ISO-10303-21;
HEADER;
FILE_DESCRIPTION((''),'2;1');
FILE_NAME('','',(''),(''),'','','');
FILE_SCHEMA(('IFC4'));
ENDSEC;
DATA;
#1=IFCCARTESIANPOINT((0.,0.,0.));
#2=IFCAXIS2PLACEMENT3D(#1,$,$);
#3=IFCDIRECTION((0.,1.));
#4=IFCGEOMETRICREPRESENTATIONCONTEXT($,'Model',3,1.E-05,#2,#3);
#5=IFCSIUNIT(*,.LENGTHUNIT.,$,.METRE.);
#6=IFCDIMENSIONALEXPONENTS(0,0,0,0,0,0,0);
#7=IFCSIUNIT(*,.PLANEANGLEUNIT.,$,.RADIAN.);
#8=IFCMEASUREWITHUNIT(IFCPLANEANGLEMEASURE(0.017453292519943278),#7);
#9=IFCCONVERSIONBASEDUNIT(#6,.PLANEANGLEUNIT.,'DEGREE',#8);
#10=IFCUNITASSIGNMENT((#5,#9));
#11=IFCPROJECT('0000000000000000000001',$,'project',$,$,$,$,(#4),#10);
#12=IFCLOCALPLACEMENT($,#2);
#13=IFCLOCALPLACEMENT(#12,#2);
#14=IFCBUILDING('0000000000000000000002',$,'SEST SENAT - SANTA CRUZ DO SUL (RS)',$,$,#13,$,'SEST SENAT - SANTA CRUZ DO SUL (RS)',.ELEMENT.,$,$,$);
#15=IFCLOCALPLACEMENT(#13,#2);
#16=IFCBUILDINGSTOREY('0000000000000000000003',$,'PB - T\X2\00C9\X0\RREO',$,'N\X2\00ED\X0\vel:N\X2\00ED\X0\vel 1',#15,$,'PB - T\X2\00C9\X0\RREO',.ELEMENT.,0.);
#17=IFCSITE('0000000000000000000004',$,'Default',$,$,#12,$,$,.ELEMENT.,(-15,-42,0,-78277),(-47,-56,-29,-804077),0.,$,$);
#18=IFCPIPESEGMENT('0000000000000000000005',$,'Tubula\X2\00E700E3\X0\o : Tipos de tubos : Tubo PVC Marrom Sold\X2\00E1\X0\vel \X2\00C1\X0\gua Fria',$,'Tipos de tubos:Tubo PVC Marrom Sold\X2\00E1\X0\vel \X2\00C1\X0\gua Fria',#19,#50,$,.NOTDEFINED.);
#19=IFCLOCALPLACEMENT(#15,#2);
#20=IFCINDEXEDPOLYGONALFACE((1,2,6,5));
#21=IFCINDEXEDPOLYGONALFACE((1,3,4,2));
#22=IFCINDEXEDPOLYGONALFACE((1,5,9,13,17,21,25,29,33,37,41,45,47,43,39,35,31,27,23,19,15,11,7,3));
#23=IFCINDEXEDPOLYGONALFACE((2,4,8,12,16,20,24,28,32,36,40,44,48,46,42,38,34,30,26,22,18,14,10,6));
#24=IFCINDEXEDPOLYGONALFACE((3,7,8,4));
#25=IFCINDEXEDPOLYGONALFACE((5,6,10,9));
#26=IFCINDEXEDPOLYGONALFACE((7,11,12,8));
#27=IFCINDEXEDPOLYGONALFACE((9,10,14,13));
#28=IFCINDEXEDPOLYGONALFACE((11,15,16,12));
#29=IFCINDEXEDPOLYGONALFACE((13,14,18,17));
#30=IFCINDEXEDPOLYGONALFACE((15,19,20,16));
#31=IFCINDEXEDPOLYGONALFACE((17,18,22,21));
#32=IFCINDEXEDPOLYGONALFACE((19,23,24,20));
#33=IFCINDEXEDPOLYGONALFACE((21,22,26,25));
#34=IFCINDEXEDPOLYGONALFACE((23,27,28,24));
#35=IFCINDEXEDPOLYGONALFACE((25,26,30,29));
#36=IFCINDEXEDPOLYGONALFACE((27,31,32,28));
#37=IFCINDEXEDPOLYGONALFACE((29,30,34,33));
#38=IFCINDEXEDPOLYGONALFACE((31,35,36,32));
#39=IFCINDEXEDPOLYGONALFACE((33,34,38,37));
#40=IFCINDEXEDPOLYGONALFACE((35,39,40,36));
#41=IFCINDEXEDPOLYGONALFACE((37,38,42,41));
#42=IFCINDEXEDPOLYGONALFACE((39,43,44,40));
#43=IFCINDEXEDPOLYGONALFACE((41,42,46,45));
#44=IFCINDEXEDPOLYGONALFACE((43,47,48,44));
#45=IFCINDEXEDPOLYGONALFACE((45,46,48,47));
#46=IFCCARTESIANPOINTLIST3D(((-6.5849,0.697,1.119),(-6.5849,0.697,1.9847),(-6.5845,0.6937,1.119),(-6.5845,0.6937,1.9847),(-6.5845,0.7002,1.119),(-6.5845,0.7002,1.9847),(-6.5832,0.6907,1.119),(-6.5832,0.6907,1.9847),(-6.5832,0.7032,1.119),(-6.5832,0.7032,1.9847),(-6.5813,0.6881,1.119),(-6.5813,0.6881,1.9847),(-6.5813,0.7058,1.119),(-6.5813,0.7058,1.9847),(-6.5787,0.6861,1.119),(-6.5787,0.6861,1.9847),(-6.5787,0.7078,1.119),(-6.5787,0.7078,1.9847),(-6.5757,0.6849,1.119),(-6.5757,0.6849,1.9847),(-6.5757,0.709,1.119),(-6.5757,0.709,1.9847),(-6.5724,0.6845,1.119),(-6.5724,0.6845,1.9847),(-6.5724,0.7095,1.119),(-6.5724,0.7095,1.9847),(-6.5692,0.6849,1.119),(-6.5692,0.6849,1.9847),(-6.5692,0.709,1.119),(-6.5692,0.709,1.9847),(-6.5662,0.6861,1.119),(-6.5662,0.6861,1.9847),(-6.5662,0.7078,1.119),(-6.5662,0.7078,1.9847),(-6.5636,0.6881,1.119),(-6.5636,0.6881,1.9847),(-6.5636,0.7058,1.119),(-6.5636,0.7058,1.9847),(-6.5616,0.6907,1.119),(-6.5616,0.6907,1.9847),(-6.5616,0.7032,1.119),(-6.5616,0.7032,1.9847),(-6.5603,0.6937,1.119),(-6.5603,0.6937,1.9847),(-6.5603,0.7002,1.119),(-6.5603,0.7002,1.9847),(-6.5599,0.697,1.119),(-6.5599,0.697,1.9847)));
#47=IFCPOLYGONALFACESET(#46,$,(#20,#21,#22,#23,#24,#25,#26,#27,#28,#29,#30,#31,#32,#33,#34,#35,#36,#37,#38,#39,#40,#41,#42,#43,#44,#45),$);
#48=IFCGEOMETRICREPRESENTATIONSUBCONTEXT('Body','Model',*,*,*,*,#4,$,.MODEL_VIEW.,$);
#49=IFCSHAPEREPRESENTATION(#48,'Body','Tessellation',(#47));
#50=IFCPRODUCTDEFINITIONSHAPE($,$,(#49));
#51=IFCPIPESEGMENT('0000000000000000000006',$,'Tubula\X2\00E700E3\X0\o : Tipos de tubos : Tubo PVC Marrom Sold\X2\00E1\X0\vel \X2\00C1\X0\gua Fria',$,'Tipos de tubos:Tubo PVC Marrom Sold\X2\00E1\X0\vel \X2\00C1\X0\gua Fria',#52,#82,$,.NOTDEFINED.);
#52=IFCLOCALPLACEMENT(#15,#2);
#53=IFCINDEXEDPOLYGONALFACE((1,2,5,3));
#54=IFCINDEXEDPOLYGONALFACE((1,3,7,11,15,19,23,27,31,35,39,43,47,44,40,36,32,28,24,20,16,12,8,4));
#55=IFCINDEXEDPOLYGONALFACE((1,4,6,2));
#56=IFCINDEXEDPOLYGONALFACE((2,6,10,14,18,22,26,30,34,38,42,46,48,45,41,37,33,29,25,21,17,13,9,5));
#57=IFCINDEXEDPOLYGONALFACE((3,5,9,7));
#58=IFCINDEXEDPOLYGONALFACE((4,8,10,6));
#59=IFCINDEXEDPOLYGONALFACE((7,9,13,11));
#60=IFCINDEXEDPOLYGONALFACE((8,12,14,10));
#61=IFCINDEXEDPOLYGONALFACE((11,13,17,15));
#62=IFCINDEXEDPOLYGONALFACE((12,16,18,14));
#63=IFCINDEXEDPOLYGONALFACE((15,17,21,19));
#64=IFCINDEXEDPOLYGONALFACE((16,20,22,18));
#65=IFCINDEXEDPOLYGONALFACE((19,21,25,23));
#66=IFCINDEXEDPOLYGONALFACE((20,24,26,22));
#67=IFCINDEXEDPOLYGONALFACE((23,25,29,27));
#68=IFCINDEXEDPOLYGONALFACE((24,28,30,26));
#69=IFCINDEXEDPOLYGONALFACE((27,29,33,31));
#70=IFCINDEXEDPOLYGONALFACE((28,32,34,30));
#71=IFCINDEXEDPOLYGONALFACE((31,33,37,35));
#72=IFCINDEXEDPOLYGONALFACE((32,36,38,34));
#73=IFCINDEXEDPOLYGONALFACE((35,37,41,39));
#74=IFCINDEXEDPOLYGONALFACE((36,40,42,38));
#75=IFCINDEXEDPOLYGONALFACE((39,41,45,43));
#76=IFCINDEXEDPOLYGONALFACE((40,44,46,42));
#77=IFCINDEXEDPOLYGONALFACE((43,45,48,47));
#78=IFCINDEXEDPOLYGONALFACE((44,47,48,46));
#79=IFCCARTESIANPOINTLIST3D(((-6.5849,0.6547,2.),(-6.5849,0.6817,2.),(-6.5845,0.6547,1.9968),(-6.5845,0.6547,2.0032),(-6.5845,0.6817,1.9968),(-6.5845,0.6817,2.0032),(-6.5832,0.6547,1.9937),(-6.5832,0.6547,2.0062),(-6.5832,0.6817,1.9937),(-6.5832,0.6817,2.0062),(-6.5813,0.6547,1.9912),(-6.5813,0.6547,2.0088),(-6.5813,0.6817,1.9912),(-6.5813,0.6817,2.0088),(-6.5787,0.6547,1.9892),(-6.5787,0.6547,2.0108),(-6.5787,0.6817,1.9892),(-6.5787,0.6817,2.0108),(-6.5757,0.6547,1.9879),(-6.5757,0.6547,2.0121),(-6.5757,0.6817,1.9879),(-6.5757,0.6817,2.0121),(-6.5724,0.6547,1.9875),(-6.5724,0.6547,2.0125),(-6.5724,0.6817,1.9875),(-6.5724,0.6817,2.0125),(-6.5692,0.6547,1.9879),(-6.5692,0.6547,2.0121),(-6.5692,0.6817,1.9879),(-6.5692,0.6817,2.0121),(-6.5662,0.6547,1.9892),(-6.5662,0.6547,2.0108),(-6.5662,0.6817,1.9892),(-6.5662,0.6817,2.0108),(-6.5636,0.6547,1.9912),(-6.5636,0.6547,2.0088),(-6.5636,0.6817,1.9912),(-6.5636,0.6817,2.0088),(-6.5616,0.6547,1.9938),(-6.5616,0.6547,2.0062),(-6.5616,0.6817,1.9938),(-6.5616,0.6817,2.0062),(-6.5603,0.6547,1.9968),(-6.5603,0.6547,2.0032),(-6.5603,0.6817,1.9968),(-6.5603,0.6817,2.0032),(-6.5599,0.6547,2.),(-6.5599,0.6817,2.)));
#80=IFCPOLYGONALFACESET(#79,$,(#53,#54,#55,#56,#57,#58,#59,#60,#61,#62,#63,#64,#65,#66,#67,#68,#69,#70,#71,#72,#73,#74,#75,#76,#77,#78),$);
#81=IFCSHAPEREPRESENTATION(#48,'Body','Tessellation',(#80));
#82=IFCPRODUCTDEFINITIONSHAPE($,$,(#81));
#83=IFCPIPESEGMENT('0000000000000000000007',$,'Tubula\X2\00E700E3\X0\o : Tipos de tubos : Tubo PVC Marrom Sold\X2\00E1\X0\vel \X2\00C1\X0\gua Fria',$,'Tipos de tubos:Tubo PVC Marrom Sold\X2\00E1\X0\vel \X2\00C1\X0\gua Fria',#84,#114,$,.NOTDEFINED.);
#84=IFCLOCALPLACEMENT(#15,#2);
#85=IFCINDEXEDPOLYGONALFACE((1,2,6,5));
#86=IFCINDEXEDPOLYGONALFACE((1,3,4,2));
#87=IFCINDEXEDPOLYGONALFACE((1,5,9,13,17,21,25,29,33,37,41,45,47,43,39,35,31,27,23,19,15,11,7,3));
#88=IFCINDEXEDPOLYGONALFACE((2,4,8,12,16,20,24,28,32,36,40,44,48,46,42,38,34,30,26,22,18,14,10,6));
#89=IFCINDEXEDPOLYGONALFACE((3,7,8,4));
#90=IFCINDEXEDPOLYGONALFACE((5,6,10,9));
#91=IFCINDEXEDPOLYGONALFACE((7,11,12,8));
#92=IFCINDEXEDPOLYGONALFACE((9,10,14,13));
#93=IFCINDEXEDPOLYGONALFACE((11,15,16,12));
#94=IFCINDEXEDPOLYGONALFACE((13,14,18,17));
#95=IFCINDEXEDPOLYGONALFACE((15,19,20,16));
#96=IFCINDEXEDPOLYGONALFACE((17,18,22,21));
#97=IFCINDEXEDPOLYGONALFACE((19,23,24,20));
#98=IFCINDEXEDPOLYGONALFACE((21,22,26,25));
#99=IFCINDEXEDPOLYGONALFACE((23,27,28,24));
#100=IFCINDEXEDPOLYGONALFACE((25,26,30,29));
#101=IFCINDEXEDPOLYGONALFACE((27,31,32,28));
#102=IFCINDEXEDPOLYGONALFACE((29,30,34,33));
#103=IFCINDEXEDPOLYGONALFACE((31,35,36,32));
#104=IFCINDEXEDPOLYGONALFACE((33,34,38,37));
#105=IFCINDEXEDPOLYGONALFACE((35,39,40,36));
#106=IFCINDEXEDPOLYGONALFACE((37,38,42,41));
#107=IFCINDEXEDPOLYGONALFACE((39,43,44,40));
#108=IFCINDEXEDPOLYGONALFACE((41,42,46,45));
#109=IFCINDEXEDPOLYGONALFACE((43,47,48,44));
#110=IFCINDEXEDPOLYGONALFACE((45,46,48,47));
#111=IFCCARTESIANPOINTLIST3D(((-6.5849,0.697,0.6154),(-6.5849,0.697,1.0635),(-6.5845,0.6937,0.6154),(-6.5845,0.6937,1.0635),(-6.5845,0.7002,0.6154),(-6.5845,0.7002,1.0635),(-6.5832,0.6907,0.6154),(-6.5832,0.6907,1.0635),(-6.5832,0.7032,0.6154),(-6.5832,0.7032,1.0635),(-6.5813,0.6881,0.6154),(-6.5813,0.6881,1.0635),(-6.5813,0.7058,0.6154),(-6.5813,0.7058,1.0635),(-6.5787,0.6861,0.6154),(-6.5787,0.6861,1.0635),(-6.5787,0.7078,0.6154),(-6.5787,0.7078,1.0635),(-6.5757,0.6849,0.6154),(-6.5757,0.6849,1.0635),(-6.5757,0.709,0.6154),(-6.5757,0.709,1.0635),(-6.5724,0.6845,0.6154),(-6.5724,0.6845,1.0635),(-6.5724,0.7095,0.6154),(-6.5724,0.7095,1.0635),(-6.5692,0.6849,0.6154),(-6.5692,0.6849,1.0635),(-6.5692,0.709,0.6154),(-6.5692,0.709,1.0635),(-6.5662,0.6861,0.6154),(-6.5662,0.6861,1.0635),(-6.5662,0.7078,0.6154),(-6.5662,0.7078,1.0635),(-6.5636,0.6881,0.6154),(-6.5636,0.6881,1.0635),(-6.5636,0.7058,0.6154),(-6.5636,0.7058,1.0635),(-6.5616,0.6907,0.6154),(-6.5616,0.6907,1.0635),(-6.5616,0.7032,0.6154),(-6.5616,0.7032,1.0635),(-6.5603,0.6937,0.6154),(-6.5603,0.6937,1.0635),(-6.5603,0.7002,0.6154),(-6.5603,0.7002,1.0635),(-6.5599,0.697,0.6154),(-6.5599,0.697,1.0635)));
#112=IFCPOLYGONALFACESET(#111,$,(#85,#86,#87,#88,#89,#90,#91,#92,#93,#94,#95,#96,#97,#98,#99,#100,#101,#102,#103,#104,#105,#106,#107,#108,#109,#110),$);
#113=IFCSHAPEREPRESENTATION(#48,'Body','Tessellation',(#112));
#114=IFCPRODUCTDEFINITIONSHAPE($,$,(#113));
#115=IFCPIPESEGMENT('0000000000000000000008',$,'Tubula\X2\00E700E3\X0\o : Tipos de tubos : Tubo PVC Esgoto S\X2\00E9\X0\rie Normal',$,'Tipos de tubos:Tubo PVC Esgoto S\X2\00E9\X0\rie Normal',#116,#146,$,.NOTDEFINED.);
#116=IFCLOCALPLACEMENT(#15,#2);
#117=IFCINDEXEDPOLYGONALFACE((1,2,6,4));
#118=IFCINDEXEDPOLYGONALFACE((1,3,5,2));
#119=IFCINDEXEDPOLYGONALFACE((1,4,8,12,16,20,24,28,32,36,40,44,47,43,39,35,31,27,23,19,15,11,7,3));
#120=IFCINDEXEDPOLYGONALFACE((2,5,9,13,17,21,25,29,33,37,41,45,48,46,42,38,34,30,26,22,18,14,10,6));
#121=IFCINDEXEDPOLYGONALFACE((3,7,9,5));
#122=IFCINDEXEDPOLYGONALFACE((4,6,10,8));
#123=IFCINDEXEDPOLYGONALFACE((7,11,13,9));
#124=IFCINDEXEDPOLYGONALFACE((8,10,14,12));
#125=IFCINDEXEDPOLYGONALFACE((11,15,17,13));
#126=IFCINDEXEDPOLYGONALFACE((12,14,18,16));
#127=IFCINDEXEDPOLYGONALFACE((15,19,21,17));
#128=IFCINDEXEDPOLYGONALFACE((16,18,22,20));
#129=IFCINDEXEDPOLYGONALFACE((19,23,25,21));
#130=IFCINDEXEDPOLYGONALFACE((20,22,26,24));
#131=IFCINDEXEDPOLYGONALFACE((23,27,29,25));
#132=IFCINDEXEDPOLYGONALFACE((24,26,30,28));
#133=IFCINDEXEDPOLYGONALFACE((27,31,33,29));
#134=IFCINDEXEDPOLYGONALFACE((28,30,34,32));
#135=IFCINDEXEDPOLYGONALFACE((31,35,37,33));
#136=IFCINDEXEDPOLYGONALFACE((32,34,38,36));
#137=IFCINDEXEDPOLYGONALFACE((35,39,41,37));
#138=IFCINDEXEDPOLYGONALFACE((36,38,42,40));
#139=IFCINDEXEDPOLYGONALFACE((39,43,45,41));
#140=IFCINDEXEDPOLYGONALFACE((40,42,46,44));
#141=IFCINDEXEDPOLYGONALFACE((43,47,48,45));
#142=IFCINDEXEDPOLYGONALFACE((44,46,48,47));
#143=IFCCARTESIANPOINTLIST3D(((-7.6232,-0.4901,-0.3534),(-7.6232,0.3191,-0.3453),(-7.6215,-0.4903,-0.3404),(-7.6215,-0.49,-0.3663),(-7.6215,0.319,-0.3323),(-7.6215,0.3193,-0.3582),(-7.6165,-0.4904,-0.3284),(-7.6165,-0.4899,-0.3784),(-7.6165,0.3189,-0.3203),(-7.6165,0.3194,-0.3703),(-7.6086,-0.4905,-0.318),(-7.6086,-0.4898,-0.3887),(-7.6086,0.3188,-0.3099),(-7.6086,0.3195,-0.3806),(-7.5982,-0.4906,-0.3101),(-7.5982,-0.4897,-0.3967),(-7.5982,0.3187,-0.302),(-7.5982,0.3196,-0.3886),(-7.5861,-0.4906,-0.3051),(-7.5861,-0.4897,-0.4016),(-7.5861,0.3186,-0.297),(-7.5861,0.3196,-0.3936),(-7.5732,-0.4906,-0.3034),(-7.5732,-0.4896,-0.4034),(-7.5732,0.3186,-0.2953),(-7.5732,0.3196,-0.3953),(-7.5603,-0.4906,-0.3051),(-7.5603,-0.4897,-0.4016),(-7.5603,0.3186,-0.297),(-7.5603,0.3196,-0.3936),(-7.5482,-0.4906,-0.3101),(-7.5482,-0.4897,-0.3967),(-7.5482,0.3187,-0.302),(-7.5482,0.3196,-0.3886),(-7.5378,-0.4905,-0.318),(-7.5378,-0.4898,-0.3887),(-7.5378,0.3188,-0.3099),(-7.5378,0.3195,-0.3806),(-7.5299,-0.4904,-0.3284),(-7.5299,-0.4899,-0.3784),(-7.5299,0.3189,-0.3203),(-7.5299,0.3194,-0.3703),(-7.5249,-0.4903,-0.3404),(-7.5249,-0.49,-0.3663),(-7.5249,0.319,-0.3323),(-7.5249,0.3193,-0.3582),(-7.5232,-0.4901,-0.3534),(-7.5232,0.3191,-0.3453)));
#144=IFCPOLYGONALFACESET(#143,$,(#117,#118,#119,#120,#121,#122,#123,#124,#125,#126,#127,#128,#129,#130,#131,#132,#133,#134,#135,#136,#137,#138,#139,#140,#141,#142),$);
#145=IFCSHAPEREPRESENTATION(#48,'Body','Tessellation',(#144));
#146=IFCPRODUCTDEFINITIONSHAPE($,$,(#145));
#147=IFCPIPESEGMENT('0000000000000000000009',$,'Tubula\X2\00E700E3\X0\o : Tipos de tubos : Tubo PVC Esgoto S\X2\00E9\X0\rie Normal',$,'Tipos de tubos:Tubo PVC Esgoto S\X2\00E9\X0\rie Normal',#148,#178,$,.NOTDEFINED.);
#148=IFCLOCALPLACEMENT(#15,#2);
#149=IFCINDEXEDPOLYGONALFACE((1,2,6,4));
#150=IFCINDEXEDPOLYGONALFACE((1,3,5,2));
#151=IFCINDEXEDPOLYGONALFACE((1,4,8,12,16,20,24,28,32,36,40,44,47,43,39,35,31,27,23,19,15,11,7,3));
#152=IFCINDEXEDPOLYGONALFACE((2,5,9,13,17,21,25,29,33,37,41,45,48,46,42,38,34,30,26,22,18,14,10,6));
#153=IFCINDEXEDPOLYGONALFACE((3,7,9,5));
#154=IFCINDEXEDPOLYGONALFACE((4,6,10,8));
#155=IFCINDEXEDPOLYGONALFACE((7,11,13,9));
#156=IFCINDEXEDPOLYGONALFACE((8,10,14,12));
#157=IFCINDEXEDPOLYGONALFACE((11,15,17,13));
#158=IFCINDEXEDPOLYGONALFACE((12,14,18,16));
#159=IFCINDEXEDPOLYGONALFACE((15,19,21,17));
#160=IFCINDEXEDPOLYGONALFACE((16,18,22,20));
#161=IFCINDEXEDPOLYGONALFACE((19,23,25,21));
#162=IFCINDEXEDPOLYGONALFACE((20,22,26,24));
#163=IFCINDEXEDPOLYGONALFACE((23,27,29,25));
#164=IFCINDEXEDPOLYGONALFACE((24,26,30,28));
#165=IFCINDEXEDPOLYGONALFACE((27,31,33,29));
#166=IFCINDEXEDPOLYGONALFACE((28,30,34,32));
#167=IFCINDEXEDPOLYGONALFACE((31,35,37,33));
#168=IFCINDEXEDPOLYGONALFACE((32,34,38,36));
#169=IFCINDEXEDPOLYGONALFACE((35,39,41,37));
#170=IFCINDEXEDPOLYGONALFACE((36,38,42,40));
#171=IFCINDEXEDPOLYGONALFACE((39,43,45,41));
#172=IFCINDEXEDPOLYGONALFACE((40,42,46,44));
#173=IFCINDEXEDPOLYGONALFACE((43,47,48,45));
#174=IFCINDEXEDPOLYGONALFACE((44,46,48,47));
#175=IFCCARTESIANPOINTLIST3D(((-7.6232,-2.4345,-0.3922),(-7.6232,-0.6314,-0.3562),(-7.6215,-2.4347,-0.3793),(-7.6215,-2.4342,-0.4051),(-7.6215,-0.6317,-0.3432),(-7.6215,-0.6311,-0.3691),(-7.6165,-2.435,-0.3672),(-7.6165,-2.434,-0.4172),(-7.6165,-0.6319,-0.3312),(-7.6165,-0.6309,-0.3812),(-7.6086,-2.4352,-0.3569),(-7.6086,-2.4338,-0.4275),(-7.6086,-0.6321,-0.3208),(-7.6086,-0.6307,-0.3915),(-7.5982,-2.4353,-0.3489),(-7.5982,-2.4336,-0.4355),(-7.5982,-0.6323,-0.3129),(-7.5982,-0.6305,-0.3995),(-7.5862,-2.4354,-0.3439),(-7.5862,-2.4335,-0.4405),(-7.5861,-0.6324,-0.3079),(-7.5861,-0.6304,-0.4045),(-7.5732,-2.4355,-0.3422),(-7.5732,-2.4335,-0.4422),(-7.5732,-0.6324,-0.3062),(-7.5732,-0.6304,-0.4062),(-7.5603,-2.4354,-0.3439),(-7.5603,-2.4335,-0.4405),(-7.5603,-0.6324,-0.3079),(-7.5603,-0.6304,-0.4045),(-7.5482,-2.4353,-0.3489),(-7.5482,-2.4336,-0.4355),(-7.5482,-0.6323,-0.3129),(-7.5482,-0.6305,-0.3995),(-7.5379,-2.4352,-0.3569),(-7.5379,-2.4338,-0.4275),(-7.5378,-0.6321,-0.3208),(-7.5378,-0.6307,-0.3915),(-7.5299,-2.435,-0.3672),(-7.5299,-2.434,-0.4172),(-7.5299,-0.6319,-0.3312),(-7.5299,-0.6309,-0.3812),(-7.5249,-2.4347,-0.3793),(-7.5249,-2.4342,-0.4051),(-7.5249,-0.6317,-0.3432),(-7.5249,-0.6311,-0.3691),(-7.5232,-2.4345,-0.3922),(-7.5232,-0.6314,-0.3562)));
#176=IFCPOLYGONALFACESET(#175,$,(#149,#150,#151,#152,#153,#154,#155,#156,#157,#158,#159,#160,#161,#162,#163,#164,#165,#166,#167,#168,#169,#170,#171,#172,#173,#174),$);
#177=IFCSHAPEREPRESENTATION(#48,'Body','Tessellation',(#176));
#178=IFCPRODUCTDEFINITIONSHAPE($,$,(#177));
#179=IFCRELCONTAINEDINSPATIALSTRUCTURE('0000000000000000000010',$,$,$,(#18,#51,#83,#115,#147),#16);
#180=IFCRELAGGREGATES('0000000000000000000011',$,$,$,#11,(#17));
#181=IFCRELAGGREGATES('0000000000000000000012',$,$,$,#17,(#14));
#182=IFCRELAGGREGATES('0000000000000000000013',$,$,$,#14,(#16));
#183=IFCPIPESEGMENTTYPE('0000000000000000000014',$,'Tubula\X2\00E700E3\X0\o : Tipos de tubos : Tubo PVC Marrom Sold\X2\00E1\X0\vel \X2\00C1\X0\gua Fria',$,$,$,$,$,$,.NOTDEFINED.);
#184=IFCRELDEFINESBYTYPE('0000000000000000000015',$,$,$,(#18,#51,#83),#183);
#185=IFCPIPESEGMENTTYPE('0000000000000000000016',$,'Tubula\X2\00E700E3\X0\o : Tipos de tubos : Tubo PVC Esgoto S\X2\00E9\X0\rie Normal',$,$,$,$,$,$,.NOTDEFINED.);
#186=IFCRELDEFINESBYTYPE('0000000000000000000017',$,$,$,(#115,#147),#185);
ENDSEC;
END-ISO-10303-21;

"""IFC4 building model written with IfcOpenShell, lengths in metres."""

from ifc_helpers import new_model, entity, si_unit, converted_unit, direction, frame, origin, place, context, subcontext, project, spatial, arc, indexed_curve, outline, extrude, type_object, element, save


model = new_model("IFC4")

# Units and contexts
model_context = context("Model", 3, precision=1e-05, world=origin(), true_north=direction((0.0, 1.0)))
body_context = subcontext(model_context, "Body", "Model", "MODEL_VIEW")
ifc_project = project(units=[si_unit("LENGTHUNIT", "METRE"), converted_unit("PLANEANGLEUNIT", "DEGREE", entity("IfcPlaneAngleMeasure", 0.017453292519943278), si_unit("PLANEANGLEUNIT", "RADIAN"), dimensions=[0, 0, 0, 0, 0, 0, 0])], contexts=[model_context])

# Site, building, storey
site_placement = place(None, origin())
site = spatial("IfcSite", under=ifc_project, at=site_placement, Name="Default", CompositionType="ELEMENT", RefLatitude=(-15, -42, 0, -78277), RefLongitude=(-47, -56, -29, -804077), RefElevation=0.0)
building_placement = place(site_placement, origin())
building = spatial("IfcBuilding", under=site, at=building_placement, Name="SEST SENAT - SANTA CRUZ DO SUL (RS)", LongName="SEST SENAT - SANTA CRUZ DO SUL (RS)", CompositionType="ELEMENT")
storey_placement = place(building_placement, origin())
storey = spatial("IfcBuildingStorey", under=building, at=storey_placement, Name="PB - TÉRREO", ObjectType="Nível:Nível 1", LongName="PB - TÉRREO", CompositionType="ELEMENT", Elevation=0.0)

# Pipe segments
pipe_segment_type_1 = type_object("IfcPipeSegmentType", Name="Tubulação : Tipos de tubos : Tubo PVC Marrom Soldável Água Fria", PredefinedType="NOTDEFINED")
pipe_segment_1_placement = place(storey_placement, frame((-6.5865, 0.6829, 1.119)))
element("IfcPipeSegment", 1, at=pipe_segment_1_placement, inside=storey, type_object=pipe_segment_type_1, Name="Tubulação : Tipos de tubos : Tubo PVC Marrom Soldável Água Fria", ObjectType="Tipos de tubos:Tubo PVC Marrom Soldável Água Fria", PredefinedType="NOTDEFINED", context=body_context, shape_type="SweptSolid", body=[
    extrude(outline(indexed_curve([(0.0125, 0.0), (0.0088, 0.0088), (0.0, 0.0125), (-0.0088, 0.0088), (-0.0125, 0.0), (-0.0088, -0.0088), (0.0, -0.0125), (0.0088, -0.0088)], segments=[arc(1, 2, 3), arc(3, 4, 5), arc(5, 6, 7), arc(7, 8, 1)], self_intersect=False)), frame((0.0141, 0.0141, 0.0), z_axis=(0.0, 0.0, 1.0), x_axis=(-1.0, 0.0, 0.0)), (0.0, 0.0, 1.0), 0.8657),
])
pipe_segment_2_placement = place(storey_placement, frame((-6.5865, 0.6547, 1.9859)))
element("IfcPipeSegment", 2, at=pipe_segment_2_placement, inside=storey, type_object=pipe_segment_type_1, Name="Tubulação : Tipos de tubos : Tubo PVC Marrom Soldável Água Fria", ObjectType="Tipos de tubos:Tubo PVC Marrom Soldável Água Fria", PredefinedType="NOTDEFINED", context=body_context, shape_type="SweptSolid", body=[
    extrude(outline(indexed_curve([(0.0125, 0.0), (0.0088, 0.0088), (0.0, 0.0125), (-0.0088, 0.0088), (-0.0125, 0.0), (-0.0088, -0.0088), (0.0, -0.0125), (0.0088, -0.0088)], segments=[arc(1, 2, 3), arc(3, 4, 5), arc(5, 6, 7), arc(7, 8, 1)], self_intersect=False)), frame((0.0141, 0.0, 0.0141), z_axis=(0.0, 1.0, 0.0), x_axis=(-1.0, 0.0, 0.0)), (0.0, 0.0, 1.0), 0.0269),
])
pipe_segment_3_placement = place(storey_placement, frame((-6.5865, 0.6829, 0.6154)))
element("IfcPipeSegment", 3, at=pipe_segment_3_placement, inside=storey, type_object=pipe_segment_type_1, Name="Tubulação : Tipos de tubos : Tubo PVC Marrom Soldável Água Fria", ObjectType="Tipos de tubos:Tubo PVC Marrom Soldável Água Fria", PredefinedType="NOTDEFINED", context=body_context, shape_type="SweptSolid", body=[
    extrude(outline(indexed_curve([(0.0125, 0.0), (0.0088, 0.0088), (0.0, 0.0125), (-0.0088, 0.0088), (-0.0125, 0.0), (-0.0088, -0.0088), (0.0, -0.0125), (0.0088, -0.0088)], segments=[arc(1, 2, 3), arc(3, 4, 5), arc(5, 6, 7), arc(7, 8, 1)], self_intersect=False)), frame((0.0141, 0.0141, 0.0), z_axis=(0.0, 0.0, 1.0), x_axis=(-1.0, 0.0, 0.0)), (0.0, 0.0, 1.0), 0.4481),
])
pipe_segment_type_2 = type_object("IfcPipeSegmentType", Name="Tubulação : Tipos de tubos : Tubo PVC Esgoto Série Normal", PredefinedType="NOTDEFINED")
pipe_segment_4_placement = place(storey_placement, frame((-7.6248, -0.4922, -0.2937)))
element("IfcPipeSegment", 4, at=pipe_segment_4_placement, inside=storey, type_object=pipe_segment_type_2, Name="Tubulação : Tipos de tubos : Tubo PVC Esgoto Série Normal", ObjectType="Tipos de tubos:Tubo PVC Esgoto Série Normal", PredefinedType="NOTDEFINED", context=body_context, shape_type="SweptSolid", body=[
    extrude(outline(indexed_curve([(0.05, 0.0), (0.0354, 0.0354), (0.0, 0.05), (-0.0354, 0.0354), (-0.05, 0.0), (-0.0354, -0.0354), (0.0, -0.05), (0.0354, -0.0354)], segments=[arc(1, 2, 3), arc(3, 4, 5), arc(5, 6, 7), arc(7, 8, 1)], self_intersect=False)), frame((0.0516, 0.0021, -0.0597), z_axis=(-0.00001, 0.99995, 0.01), x_axis=(1.0, 0.00001, 0.0)), (0.0, 0.0, 1.0), 0.8093),
])
pipe_segment_5_placement = place(storey_placement, frame((-7.6248, -2.4371, -0.4438)))
element("IfcPipeSegment", 5, at=pipe_segment_5_placement, inside=storey, type_object=pipe_segment_type_2, Name="Tubulação : Tipos de tubos : Tubo PVC Esgoto Série Normal", ObjectType="Tipos de tubos:Tubo PVC Esgoto Série Normal", PredefinedType="NOTDEFINED", context=body_context, shape_type="SweptSolid", body=[
    extrude(outline(indexed_curve([(0.05, 0.0), (0.0354, 0.0354), (0.0, 0.05), (-0.0354, 0.0354), (-0.05, 0.0), (-0.0354, -0.0354), (0.0, -0.05), (0.0354, -0.0354)], segments=[arc(1, 2, 3), arc(3, 4, 5), arc(5, 6, 7), arc(7, 8, 1)], self_intersect=False)), frame((0.0516, 0.0026, 0.0516), z_axis=(0.000014, 0.9998, 0.019976), x_axis=(1.0, -0.000014, 0.0)), (0.0, 0.0, 1.0), 1.8034),
])

save(model, "model.ifc")
